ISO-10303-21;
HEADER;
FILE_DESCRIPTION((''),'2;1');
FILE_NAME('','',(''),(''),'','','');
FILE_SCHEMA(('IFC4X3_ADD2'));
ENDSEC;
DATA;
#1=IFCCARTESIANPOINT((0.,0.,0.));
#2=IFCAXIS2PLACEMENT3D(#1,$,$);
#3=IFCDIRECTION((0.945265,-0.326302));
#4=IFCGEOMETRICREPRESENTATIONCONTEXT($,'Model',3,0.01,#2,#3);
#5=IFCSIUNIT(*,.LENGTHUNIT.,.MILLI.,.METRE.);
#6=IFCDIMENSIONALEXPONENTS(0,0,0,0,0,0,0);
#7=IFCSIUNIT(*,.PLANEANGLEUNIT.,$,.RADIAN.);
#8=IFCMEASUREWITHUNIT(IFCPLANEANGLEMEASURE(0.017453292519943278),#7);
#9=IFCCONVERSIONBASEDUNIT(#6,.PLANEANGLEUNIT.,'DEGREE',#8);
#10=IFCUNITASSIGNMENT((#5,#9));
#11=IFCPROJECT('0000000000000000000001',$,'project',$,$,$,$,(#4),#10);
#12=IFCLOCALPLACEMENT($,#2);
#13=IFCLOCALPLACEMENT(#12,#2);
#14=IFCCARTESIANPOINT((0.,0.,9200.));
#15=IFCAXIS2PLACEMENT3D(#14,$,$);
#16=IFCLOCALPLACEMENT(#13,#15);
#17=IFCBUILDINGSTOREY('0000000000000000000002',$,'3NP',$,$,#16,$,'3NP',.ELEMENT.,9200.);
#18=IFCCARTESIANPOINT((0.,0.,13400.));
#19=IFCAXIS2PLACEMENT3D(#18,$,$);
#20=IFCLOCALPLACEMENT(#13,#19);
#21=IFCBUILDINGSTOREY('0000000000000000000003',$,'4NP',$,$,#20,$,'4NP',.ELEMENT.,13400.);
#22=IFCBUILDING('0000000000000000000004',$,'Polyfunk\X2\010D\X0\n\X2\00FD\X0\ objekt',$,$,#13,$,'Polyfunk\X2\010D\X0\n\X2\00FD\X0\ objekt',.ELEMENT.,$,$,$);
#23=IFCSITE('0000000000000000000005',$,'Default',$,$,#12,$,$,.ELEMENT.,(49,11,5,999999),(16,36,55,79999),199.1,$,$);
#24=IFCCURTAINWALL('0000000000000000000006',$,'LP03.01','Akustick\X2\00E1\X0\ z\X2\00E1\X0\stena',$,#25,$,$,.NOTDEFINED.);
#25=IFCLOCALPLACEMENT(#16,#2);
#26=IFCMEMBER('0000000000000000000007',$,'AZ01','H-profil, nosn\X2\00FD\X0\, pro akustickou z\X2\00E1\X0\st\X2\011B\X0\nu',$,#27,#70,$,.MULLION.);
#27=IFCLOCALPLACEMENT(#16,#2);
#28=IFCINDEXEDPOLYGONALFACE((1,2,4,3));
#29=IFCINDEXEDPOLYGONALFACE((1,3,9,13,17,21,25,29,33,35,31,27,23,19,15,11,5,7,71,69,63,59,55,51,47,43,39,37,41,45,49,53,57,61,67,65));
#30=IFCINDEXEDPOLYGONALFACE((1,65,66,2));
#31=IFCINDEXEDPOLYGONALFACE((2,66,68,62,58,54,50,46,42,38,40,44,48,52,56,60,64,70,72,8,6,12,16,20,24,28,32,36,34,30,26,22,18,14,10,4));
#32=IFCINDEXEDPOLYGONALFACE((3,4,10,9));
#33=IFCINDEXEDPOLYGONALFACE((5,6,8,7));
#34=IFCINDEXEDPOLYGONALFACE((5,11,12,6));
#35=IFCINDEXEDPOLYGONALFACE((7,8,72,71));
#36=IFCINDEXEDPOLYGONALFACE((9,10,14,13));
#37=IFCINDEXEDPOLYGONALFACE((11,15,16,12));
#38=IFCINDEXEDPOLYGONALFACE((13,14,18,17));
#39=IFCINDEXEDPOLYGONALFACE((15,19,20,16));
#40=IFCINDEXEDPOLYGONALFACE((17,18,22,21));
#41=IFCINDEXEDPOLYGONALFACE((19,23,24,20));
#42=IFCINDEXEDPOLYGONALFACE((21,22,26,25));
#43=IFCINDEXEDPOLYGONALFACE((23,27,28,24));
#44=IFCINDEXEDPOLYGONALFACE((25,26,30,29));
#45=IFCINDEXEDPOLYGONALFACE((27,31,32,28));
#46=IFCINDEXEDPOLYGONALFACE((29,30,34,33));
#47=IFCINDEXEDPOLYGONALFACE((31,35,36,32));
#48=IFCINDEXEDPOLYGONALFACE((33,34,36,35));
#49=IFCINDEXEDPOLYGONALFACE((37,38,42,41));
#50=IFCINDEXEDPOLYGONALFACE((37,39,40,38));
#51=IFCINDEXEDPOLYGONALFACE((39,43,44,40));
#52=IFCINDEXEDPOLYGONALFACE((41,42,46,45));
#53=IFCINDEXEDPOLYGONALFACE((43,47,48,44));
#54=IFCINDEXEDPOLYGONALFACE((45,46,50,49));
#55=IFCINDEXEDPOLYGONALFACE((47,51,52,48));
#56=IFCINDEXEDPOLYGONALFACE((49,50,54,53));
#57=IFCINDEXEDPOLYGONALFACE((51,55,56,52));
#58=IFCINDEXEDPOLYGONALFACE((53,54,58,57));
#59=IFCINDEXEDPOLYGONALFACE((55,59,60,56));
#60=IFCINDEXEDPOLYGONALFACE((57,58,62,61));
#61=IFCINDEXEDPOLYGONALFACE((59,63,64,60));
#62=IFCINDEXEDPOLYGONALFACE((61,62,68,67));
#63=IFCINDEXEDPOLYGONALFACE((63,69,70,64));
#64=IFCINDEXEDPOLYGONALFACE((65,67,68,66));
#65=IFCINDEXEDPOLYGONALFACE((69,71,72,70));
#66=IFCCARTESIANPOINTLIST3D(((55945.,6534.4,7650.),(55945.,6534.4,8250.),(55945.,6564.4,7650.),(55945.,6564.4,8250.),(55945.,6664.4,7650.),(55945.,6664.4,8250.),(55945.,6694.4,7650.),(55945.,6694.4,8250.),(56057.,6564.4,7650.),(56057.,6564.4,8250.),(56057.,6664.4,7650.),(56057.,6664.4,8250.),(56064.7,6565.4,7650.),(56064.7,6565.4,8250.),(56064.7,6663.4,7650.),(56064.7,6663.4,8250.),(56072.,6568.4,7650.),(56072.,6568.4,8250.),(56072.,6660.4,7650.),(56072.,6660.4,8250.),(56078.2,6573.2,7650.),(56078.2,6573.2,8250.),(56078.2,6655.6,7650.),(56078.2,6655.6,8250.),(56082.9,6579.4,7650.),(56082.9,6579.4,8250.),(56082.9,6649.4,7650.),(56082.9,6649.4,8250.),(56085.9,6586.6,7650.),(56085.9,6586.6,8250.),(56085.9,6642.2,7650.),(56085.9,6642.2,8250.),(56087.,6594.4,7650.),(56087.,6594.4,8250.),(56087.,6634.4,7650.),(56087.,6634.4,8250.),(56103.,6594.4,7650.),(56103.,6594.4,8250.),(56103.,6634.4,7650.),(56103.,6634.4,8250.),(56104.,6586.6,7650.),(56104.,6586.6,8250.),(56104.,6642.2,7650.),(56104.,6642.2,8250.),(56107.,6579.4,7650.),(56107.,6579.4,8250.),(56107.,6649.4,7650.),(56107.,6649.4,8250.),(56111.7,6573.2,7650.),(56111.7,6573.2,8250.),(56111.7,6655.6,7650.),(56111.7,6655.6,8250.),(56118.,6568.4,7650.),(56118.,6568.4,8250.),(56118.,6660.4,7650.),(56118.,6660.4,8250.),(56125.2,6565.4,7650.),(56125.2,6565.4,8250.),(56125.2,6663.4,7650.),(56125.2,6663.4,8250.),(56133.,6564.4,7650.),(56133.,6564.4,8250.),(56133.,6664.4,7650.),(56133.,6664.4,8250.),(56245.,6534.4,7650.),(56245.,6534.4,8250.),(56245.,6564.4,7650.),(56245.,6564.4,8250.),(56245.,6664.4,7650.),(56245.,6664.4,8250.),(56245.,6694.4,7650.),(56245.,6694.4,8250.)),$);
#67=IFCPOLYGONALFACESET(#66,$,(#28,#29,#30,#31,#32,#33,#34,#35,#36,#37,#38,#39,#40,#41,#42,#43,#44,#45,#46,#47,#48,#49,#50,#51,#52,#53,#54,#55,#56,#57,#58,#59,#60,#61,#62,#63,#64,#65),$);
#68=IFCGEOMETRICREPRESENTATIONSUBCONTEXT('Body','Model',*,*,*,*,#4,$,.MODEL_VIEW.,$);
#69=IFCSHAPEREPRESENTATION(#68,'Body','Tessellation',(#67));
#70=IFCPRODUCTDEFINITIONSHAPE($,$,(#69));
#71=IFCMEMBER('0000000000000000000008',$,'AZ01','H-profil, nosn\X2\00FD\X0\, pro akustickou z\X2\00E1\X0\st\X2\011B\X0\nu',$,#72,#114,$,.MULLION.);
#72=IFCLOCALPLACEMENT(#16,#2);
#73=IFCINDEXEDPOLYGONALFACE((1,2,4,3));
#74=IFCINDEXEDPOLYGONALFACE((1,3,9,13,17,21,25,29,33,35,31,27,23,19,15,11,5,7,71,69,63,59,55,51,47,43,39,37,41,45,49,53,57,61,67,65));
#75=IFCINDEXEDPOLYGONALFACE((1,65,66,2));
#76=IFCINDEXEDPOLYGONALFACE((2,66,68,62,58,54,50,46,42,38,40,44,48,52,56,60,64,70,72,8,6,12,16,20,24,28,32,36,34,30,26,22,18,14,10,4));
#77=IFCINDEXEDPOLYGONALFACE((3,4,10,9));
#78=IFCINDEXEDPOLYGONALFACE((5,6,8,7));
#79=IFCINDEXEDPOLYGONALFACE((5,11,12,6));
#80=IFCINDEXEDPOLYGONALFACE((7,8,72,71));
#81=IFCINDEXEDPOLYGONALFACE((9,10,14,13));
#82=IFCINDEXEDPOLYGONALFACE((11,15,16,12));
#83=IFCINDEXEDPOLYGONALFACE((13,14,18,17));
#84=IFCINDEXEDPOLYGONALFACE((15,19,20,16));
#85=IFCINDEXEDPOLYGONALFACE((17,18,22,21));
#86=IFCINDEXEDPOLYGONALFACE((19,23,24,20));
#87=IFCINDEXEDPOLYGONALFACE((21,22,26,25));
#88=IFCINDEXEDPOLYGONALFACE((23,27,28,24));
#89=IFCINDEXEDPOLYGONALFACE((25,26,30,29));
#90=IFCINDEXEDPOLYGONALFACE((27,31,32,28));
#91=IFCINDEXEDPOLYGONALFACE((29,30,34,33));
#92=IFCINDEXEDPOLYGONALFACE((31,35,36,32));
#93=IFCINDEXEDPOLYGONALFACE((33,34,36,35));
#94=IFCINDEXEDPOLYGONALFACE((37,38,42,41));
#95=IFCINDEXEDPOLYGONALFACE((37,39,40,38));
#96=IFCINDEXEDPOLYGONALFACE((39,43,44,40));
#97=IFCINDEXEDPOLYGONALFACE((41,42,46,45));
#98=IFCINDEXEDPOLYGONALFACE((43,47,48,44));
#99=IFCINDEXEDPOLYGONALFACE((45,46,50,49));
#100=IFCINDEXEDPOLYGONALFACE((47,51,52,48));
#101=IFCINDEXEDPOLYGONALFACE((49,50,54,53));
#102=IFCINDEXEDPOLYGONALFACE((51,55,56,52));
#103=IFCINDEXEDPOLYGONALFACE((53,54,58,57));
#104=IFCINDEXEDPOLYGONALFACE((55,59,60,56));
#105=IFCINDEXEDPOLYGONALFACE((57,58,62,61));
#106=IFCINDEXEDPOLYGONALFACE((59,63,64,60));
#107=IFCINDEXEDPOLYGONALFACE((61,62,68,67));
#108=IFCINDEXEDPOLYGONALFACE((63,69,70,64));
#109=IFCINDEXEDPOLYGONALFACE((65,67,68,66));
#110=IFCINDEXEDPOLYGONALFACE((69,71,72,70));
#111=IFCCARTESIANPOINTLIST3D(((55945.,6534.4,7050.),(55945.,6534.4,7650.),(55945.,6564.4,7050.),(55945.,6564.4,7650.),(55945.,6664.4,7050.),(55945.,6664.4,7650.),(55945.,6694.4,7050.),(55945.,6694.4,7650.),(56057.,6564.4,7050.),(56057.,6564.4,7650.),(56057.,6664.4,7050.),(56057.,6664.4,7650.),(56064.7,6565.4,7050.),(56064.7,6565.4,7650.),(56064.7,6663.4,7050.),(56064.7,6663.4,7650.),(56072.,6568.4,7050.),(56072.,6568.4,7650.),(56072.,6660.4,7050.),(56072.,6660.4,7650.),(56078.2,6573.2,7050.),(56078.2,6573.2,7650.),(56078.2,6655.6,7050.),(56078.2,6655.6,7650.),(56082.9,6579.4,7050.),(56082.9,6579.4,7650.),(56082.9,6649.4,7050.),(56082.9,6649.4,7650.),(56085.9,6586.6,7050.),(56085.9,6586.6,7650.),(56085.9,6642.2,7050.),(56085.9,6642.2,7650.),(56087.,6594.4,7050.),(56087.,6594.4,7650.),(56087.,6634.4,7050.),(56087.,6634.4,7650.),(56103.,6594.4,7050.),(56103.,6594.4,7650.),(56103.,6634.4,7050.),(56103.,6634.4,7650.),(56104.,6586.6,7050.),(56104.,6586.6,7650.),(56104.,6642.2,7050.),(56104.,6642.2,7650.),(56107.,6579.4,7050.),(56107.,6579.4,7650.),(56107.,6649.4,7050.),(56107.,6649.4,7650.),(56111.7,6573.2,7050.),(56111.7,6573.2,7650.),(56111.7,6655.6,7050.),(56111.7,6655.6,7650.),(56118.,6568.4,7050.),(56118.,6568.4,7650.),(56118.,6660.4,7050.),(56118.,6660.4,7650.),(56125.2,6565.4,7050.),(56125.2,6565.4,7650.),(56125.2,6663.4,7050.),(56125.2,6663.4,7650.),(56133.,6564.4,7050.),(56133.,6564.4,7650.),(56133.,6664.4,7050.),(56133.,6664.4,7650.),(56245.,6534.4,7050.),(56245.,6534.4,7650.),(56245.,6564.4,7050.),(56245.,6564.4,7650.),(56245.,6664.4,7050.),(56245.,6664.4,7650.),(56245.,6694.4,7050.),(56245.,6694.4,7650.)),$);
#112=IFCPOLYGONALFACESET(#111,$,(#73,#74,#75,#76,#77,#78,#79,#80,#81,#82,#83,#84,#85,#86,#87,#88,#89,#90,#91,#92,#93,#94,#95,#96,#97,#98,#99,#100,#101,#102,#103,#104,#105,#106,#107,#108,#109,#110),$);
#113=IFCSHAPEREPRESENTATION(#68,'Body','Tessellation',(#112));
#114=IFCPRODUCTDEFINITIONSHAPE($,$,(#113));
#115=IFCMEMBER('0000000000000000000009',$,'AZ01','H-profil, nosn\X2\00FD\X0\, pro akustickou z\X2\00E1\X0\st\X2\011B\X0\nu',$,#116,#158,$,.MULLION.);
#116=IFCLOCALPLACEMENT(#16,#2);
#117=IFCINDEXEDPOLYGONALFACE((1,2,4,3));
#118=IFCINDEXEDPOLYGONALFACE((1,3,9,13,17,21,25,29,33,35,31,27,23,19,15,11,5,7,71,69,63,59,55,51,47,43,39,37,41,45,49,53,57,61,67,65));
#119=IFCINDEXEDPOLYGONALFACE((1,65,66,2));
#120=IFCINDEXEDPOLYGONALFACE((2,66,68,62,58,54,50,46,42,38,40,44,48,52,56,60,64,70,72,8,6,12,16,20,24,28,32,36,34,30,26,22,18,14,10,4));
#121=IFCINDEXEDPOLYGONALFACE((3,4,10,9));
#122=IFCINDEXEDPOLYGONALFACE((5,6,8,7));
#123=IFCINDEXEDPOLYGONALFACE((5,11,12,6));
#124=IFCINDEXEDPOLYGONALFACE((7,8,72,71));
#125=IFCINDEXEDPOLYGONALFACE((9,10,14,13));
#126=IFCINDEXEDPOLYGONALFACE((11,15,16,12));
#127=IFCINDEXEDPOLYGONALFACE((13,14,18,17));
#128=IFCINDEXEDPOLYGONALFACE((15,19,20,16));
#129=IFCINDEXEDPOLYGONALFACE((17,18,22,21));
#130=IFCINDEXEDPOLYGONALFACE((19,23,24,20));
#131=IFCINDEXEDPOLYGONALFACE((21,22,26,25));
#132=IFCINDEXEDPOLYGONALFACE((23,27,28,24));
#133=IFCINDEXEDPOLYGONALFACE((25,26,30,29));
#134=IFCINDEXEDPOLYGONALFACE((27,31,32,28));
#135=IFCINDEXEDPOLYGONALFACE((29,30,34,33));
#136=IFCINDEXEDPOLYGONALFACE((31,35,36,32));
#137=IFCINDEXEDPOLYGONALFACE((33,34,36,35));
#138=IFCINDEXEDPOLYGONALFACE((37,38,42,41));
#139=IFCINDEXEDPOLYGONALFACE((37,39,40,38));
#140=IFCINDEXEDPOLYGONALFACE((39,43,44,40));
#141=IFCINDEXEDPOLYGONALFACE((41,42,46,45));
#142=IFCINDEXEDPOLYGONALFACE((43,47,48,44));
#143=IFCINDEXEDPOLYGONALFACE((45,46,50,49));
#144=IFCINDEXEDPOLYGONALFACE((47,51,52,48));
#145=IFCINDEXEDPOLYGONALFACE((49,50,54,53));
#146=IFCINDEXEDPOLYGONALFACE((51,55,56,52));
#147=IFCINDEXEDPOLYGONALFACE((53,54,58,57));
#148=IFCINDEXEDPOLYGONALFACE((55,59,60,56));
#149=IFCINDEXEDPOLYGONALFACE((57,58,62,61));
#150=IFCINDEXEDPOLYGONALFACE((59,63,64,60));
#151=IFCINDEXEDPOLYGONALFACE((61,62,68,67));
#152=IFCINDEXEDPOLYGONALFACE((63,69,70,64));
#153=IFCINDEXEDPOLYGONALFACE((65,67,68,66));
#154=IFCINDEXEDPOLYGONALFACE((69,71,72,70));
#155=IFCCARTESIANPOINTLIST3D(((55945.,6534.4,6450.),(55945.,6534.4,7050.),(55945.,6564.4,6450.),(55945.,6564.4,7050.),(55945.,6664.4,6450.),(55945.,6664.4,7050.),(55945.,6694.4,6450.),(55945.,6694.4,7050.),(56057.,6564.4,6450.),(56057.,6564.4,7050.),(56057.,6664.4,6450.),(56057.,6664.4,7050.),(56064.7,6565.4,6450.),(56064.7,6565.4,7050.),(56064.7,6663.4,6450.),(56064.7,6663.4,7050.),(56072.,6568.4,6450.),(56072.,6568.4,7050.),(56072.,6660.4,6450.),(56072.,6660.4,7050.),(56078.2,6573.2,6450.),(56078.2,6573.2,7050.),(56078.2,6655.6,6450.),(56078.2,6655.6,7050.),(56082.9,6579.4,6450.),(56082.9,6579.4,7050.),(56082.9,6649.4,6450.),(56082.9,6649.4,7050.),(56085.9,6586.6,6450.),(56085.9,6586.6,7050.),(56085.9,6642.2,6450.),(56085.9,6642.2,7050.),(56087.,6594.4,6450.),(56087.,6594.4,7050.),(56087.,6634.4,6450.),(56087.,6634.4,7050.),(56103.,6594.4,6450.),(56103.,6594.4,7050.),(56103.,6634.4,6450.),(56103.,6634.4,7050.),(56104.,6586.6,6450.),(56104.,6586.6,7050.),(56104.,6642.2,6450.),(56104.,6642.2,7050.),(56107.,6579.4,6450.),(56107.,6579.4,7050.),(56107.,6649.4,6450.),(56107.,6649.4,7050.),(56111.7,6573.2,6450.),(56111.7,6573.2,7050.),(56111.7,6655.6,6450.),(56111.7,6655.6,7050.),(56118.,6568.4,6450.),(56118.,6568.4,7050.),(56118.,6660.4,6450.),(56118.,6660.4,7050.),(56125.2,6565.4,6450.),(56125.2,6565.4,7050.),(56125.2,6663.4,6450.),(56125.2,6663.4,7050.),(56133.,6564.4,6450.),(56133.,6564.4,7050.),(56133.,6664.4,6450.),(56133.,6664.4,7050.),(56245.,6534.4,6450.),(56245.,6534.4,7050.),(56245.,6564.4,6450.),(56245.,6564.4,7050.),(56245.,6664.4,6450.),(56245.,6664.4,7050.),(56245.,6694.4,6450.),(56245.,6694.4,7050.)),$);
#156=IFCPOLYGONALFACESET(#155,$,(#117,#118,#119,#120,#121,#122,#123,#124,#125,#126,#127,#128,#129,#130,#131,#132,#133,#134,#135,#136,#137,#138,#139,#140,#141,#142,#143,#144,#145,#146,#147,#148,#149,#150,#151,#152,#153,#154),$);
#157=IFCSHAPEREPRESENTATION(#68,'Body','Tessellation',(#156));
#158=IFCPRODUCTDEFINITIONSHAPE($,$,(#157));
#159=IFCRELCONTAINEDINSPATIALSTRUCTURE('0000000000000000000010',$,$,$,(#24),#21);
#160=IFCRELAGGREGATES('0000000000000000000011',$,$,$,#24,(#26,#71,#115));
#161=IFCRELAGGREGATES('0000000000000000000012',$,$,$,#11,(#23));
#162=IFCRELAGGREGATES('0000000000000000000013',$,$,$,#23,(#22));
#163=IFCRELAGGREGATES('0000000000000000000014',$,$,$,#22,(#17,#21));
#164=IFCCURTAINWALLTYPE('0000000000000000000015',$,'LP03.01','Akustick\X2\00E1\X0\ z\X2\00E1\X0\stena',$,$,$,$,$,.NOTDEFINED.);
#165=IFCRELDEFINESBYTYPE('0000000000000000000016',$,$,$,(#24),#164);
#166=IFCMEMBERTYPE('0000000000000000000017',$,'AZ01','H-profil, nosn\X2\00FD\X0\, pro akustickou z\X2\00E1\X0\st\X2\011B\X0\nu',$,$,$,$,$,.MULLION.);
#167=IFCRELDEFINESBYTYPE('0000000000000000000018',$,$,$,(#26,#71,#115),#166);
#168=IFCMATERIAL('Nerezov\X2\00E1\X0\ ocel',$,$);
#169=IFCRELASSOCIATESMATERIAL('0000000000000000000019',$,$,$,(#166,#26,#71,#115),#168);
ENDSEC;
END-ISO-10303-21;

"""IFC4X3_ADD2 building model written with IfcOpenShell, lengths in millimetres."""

from ifc_helpers import new_model, entity, si_unit, converted_unit, direction, frame, frame_2d, origin, place, context, subcontext, project, spatial, polyline, circle_curve, parameter, trimmed, segment, composite_curve, outline, extrude, source, transform, mapped, material, material_profile, profile_set, profile_usage, type_object, element, aggregate, save


model = new_model("IFC4X3_ADD2")

# Units and contexts
model_context = context("Model", 3, precision=0.01, world=origin(), true_north=direction((0.945265, -0.326302)))
body_context = subcontext(model_context, "Body", "Model", "MODEL_VIEW")
ifc_project = project(units=[si_unit("LENGTHUNIT", "METRE", prefix="MILLI"), converted_unit("PLANEANGLEUNIT", "DEGREE", entity("IfcPlaneAngleMeasure", 0.017453292519943278), si_unit("PLANEANGLEUNIT", "RADIAN"), dimensions=[0, 0, 0, 0, 0, 0, 0])], contexts=[model_context])

# Site, building, storey
site_placement = place(None, origin())
site = spatial("IfcSite", under=ifc_project, at=site_placement, Name="Default", CompositionType="ELEMENT", RefLatitude=(49, 11, 5, 999999), RefLongitude=(16, 36, 55, 79999), RefElevation=199.1)
building_placement = place(site_placement, origin())
building = spatial("IfcBuilding", under=site, at=building_placement, Name="Polyfunkčný objekt", LongName="Polyfunkčný objekt", CompositionType="ELEMENT")
storey_1_placement = place(building_placement, frame((0.0, 0.0, 9200.0)))
storey_1 = spatial("IfcBuildingStorey", under=building, at=storey_1_placement, Name="3NP", LongName="3NP", CompositionType="ELEMENT", Elevation=9200.0)

# Shared definitions
storey_2_placement = place(building_placement, frame((0.0, 0.0, 13400.0)))
storey_2 = spatial("IfcBuildingStorey", under=building, at=storey_2_placement, Name="4NP", LongName="4NP", CompositionType="ELEMENT", Elevation=13400.0)

# Curtain wall, members
curtain_wall_type_1 = type_object("IfcCurtainWallType", Name="LP03.01", Description="Akustická zástena", PredefinedType="NOTDEFINED")
curtain_wall_1_placement = place(storey_2_placement, frame((0.0, 0.0, -13400.0)))
curtain_wall_1 = element("IfcCurtainWall", 1, at=curtain_wall_1_placement, inside=storey_2, type_object=curtain_wall_type_1, Name="LP03.01", Description="Akustická zástena", PredefinedType="NOTDEFINED")
ifc_material_1 = material(Name="Nerezová ocel")
ifc_material_profile_1 = material_profile(ifc_material_1, outline(composite_curve([segment(polyline([(50.0, -150.0), (80.0, -150.0)]), True, "CONTINUOUS"), segment(polyline([(80.0, -150.0), (80.0, 150.0)]), True, "CONTINUOUS"), segment(polyline([(80.0, 150.0), (50.0, 150.0)]), True, "CONTINUOUS"), segment(polyline([(50.0, 150.0), (50.0, 38.0)]), True, "CONTINUOUS"), segment(trimmed(circle_curve(frame_2d((20.0, 38.0), x_axis=(0.0, 1.0)), 30.0), [parameter(180.0)], [parameter(270.0)], True, "PARAMETER"), False, "CONTINUOUS"), segment(polyline([(20.0, 8.0), (-20.0, 8.0)]), True, "CONTINUOUS"), segment(trimmed(circle_curve(frame_2d((-20.0, 38.0), x_axis=(0.0, 1.0)), 30.0), [parameter(90.0)], [parameter(180.0)], True, "PARAMETER"), False, "CONTINUOUS"), segment(polyline([(-50.0, 38.0), (-50.0, 150.0)]), True, "CONTINUOUS"), segment(polyline([(-50.0, 150.0), (-80.0, 150.0)]), True, "CONTINUOUS"), segment(polyline([(-80.0, 150.0), (-80.0, -150.0)]), True, "CONTINUOUS"), segment(polyline([(-80.0, -150.0), (-50.0, -150.0)]), True, "CONTINUOUS"), segment(polyline([(-50.0, -150.0), (-50.0, -38.0)]), True, "CONTINUOUS"), segment(trimmed(circle_curve(frame_2d((-20.0, -38.0), x_axis=(0.0, 1.0)), 30.0), [parameter(0.0)], [parameter(90.0)], True, "PARAMETER"), False, "CONTINUOUS"), segment(polyline([(-20.0, -8.0), (20.0, -8.0)]), True, "CONTINUOUS"), segment(trimmed(circle_curve(frame_2d((20.0, -38.0), x_axis=(0.0, 1.0)), 30.0), [parameter(270.0)], [parameter(0.0)], True, "PARAMETER"), False, "CONTINUOUS"), segment(polyline([(50.0, -38.0), (50.0, -150.0)]), True, "CONTINUOUS")], self_intersect=False)), Name="Profil zástena")
ifc_profile_set_1 = profile_set([ifc_material_profile_1], Name="Profil zástena")
ifc_profile_usage_1 = profile_usage(ifc_profile_set_1)
member_type_1 = type_object("IfcMemberType", Name="AZ01", Description="H-profil, nosný, pro akustickou zástěnu", PredefinedType="MULLION", material=ifc_profile_set_1)
shared_shape_1 = source(origin(), body_context, "Body", "SweptSolid", [
    extrude(outline(composite_curve([segment(polyline([(50.0, -150.0), (80.0, -150.0)]), True, "CONTINUOUS"), segment(polyline([(80.0, -150.0), (80.0, 150.0)]), True, "CONTINUOUS"), segment(polyline([(80.0, 150.0), (50.0, 150.0)]), True, "CONTINUOUS"), segment(polyline([(50.0, 150.0), (50.0, 38.0)]), True, "CONTINUOUS"), segment(trimmed(circle_curve(frame_2d((20.0, 38.0), x_axis=(0.0, 1.0)), 30.0), [parameter(180.0)], [parameter(270.0)], True, "PARAMETER"), False, "CONTINUOUS"), segment(polyline([(20.0, 8.0), (-20.0, 8.0)]), True, "CONTINUOUS"), segment(trimmed(circle_curve(frame_2d((-20.0, 38.0), x_axis=(0.0, 1.0)), 30.0), [parameter(90.0)], [parameter(180.0)], True, "PARAMETER"), False, "CONTINUOUS"), segment(polyline([(-50.0, 38.0), (-50.0, 150.0)]), True, "CONTINUOUS"), segment(polyline([(-50.0, 150.0), (-80.0, 150.0)]), True, "CONTINUOUS"), segment(polyline([(-80.0, 150.0), (-80.0, -150.0)]), True, "CONTINUOUS"), segment(polyline([(-80.0, -150.0), (-50.0, -150.0)]), True, "CONTINUOUS"), segment(polyline([(-50.0, -150.0), (-50.0, -38.0)]), True, "CONTINUOUS"), segment(trimmed(circle_curve(frame_2d((-20.0, -38.0), x_axis=(0.0, 1.0)), 30.0), [parameter(0.0)], [parameter(90.0)], True, "PARAMETER"), False, "CONTINUOUS"), segment(polyline([(-20.0, -8.0), (20.0, -8.0)]), True, "CONTINUOUS"), segment(trimmed(circle_curve(frame_2d((20.0, -38.0), x_axis=(0.0, 1.0)), 30.0), [parameter(270.0)], [parameter(0.0)], True, "PARAMETER"), False, "CONTINUOUS"), segment(polyline([(50.0, -38.0), (50.0, -150.0)]), True, "CONTINUOUS")], self_intersect=False)), frame((-150.0, 0.0, -600.0), z_axis=(0.0, 0.0, 1.0), x_axis=(0.0, -1.0, 0.0)), (0.0, 0.0, 1.0), 600.0),
])
member_1_placement = place(curtain_wall_1_placement, frame((56245.0, 6614.4, 16850.0), z_axis=(0.0, 0.0, -1.0), x_axis=(1.0, 0.0, 0.0)))
member_1 = element("IfcMember", 2, at=member_1_placement, type_object=member_type_1, material=ifc_profile_usage_1, Name="AZ01", Description="H-profil, nosný, pro akustickou zástěnu", PredefinedType="MULLION", context=body_context, shape_type="MappedRepresentation", body=[
    mapped(shared_shape_1, transform((0.0, 0.0, 0.0), scale=1.0)),
])
member_2_placement = place(curtain_wall_1_placement, frame((56245.0, 6614.4, 16250.0), z_axis=(0.0, 0.0, -1.0), x_axis=(1.0, 0.0, 0.0)))
member_2 = element("IfcMember", 3, at=member_2_placement, type_object=member_type_1, material=ifc_profile_usage_1, Name="AZ01", Description="H-profil, nosný, pro akustickou zástěnu", PredefinedType="MULLION", context=body_context, shape_type="MappedRepresentation", body=[
    mapped(shared_shape_1, transform((0.0, 0.0, 0.0), scale=1.0)),
])
member_3_placement = place(curtain_wall_1_placement, frame((56245.0, 6614.4, 15650.0), z_axis=(0.0, 0.0, -1.0), x_axis=(1.0, 0.0, 0.0)))
member_3 = element("IfcMember", 4, at=member_3_placement, type_object=member_type_1, material=ifc_profile_usage_1, Name="AZ01", Description="H-profil, nosný, pro akustickou zástěnu", PredefinedType="MULLION", context=body_context, shape_type="MappedRepresentation", body=[
    mapped(shared_shape_1, transform((0.0, 0.0, 0.0), scale=1.0)),
])
aggregate(curtain_wall_1, [member_1, member_2, member_3])

save(model, "model.ifc")
